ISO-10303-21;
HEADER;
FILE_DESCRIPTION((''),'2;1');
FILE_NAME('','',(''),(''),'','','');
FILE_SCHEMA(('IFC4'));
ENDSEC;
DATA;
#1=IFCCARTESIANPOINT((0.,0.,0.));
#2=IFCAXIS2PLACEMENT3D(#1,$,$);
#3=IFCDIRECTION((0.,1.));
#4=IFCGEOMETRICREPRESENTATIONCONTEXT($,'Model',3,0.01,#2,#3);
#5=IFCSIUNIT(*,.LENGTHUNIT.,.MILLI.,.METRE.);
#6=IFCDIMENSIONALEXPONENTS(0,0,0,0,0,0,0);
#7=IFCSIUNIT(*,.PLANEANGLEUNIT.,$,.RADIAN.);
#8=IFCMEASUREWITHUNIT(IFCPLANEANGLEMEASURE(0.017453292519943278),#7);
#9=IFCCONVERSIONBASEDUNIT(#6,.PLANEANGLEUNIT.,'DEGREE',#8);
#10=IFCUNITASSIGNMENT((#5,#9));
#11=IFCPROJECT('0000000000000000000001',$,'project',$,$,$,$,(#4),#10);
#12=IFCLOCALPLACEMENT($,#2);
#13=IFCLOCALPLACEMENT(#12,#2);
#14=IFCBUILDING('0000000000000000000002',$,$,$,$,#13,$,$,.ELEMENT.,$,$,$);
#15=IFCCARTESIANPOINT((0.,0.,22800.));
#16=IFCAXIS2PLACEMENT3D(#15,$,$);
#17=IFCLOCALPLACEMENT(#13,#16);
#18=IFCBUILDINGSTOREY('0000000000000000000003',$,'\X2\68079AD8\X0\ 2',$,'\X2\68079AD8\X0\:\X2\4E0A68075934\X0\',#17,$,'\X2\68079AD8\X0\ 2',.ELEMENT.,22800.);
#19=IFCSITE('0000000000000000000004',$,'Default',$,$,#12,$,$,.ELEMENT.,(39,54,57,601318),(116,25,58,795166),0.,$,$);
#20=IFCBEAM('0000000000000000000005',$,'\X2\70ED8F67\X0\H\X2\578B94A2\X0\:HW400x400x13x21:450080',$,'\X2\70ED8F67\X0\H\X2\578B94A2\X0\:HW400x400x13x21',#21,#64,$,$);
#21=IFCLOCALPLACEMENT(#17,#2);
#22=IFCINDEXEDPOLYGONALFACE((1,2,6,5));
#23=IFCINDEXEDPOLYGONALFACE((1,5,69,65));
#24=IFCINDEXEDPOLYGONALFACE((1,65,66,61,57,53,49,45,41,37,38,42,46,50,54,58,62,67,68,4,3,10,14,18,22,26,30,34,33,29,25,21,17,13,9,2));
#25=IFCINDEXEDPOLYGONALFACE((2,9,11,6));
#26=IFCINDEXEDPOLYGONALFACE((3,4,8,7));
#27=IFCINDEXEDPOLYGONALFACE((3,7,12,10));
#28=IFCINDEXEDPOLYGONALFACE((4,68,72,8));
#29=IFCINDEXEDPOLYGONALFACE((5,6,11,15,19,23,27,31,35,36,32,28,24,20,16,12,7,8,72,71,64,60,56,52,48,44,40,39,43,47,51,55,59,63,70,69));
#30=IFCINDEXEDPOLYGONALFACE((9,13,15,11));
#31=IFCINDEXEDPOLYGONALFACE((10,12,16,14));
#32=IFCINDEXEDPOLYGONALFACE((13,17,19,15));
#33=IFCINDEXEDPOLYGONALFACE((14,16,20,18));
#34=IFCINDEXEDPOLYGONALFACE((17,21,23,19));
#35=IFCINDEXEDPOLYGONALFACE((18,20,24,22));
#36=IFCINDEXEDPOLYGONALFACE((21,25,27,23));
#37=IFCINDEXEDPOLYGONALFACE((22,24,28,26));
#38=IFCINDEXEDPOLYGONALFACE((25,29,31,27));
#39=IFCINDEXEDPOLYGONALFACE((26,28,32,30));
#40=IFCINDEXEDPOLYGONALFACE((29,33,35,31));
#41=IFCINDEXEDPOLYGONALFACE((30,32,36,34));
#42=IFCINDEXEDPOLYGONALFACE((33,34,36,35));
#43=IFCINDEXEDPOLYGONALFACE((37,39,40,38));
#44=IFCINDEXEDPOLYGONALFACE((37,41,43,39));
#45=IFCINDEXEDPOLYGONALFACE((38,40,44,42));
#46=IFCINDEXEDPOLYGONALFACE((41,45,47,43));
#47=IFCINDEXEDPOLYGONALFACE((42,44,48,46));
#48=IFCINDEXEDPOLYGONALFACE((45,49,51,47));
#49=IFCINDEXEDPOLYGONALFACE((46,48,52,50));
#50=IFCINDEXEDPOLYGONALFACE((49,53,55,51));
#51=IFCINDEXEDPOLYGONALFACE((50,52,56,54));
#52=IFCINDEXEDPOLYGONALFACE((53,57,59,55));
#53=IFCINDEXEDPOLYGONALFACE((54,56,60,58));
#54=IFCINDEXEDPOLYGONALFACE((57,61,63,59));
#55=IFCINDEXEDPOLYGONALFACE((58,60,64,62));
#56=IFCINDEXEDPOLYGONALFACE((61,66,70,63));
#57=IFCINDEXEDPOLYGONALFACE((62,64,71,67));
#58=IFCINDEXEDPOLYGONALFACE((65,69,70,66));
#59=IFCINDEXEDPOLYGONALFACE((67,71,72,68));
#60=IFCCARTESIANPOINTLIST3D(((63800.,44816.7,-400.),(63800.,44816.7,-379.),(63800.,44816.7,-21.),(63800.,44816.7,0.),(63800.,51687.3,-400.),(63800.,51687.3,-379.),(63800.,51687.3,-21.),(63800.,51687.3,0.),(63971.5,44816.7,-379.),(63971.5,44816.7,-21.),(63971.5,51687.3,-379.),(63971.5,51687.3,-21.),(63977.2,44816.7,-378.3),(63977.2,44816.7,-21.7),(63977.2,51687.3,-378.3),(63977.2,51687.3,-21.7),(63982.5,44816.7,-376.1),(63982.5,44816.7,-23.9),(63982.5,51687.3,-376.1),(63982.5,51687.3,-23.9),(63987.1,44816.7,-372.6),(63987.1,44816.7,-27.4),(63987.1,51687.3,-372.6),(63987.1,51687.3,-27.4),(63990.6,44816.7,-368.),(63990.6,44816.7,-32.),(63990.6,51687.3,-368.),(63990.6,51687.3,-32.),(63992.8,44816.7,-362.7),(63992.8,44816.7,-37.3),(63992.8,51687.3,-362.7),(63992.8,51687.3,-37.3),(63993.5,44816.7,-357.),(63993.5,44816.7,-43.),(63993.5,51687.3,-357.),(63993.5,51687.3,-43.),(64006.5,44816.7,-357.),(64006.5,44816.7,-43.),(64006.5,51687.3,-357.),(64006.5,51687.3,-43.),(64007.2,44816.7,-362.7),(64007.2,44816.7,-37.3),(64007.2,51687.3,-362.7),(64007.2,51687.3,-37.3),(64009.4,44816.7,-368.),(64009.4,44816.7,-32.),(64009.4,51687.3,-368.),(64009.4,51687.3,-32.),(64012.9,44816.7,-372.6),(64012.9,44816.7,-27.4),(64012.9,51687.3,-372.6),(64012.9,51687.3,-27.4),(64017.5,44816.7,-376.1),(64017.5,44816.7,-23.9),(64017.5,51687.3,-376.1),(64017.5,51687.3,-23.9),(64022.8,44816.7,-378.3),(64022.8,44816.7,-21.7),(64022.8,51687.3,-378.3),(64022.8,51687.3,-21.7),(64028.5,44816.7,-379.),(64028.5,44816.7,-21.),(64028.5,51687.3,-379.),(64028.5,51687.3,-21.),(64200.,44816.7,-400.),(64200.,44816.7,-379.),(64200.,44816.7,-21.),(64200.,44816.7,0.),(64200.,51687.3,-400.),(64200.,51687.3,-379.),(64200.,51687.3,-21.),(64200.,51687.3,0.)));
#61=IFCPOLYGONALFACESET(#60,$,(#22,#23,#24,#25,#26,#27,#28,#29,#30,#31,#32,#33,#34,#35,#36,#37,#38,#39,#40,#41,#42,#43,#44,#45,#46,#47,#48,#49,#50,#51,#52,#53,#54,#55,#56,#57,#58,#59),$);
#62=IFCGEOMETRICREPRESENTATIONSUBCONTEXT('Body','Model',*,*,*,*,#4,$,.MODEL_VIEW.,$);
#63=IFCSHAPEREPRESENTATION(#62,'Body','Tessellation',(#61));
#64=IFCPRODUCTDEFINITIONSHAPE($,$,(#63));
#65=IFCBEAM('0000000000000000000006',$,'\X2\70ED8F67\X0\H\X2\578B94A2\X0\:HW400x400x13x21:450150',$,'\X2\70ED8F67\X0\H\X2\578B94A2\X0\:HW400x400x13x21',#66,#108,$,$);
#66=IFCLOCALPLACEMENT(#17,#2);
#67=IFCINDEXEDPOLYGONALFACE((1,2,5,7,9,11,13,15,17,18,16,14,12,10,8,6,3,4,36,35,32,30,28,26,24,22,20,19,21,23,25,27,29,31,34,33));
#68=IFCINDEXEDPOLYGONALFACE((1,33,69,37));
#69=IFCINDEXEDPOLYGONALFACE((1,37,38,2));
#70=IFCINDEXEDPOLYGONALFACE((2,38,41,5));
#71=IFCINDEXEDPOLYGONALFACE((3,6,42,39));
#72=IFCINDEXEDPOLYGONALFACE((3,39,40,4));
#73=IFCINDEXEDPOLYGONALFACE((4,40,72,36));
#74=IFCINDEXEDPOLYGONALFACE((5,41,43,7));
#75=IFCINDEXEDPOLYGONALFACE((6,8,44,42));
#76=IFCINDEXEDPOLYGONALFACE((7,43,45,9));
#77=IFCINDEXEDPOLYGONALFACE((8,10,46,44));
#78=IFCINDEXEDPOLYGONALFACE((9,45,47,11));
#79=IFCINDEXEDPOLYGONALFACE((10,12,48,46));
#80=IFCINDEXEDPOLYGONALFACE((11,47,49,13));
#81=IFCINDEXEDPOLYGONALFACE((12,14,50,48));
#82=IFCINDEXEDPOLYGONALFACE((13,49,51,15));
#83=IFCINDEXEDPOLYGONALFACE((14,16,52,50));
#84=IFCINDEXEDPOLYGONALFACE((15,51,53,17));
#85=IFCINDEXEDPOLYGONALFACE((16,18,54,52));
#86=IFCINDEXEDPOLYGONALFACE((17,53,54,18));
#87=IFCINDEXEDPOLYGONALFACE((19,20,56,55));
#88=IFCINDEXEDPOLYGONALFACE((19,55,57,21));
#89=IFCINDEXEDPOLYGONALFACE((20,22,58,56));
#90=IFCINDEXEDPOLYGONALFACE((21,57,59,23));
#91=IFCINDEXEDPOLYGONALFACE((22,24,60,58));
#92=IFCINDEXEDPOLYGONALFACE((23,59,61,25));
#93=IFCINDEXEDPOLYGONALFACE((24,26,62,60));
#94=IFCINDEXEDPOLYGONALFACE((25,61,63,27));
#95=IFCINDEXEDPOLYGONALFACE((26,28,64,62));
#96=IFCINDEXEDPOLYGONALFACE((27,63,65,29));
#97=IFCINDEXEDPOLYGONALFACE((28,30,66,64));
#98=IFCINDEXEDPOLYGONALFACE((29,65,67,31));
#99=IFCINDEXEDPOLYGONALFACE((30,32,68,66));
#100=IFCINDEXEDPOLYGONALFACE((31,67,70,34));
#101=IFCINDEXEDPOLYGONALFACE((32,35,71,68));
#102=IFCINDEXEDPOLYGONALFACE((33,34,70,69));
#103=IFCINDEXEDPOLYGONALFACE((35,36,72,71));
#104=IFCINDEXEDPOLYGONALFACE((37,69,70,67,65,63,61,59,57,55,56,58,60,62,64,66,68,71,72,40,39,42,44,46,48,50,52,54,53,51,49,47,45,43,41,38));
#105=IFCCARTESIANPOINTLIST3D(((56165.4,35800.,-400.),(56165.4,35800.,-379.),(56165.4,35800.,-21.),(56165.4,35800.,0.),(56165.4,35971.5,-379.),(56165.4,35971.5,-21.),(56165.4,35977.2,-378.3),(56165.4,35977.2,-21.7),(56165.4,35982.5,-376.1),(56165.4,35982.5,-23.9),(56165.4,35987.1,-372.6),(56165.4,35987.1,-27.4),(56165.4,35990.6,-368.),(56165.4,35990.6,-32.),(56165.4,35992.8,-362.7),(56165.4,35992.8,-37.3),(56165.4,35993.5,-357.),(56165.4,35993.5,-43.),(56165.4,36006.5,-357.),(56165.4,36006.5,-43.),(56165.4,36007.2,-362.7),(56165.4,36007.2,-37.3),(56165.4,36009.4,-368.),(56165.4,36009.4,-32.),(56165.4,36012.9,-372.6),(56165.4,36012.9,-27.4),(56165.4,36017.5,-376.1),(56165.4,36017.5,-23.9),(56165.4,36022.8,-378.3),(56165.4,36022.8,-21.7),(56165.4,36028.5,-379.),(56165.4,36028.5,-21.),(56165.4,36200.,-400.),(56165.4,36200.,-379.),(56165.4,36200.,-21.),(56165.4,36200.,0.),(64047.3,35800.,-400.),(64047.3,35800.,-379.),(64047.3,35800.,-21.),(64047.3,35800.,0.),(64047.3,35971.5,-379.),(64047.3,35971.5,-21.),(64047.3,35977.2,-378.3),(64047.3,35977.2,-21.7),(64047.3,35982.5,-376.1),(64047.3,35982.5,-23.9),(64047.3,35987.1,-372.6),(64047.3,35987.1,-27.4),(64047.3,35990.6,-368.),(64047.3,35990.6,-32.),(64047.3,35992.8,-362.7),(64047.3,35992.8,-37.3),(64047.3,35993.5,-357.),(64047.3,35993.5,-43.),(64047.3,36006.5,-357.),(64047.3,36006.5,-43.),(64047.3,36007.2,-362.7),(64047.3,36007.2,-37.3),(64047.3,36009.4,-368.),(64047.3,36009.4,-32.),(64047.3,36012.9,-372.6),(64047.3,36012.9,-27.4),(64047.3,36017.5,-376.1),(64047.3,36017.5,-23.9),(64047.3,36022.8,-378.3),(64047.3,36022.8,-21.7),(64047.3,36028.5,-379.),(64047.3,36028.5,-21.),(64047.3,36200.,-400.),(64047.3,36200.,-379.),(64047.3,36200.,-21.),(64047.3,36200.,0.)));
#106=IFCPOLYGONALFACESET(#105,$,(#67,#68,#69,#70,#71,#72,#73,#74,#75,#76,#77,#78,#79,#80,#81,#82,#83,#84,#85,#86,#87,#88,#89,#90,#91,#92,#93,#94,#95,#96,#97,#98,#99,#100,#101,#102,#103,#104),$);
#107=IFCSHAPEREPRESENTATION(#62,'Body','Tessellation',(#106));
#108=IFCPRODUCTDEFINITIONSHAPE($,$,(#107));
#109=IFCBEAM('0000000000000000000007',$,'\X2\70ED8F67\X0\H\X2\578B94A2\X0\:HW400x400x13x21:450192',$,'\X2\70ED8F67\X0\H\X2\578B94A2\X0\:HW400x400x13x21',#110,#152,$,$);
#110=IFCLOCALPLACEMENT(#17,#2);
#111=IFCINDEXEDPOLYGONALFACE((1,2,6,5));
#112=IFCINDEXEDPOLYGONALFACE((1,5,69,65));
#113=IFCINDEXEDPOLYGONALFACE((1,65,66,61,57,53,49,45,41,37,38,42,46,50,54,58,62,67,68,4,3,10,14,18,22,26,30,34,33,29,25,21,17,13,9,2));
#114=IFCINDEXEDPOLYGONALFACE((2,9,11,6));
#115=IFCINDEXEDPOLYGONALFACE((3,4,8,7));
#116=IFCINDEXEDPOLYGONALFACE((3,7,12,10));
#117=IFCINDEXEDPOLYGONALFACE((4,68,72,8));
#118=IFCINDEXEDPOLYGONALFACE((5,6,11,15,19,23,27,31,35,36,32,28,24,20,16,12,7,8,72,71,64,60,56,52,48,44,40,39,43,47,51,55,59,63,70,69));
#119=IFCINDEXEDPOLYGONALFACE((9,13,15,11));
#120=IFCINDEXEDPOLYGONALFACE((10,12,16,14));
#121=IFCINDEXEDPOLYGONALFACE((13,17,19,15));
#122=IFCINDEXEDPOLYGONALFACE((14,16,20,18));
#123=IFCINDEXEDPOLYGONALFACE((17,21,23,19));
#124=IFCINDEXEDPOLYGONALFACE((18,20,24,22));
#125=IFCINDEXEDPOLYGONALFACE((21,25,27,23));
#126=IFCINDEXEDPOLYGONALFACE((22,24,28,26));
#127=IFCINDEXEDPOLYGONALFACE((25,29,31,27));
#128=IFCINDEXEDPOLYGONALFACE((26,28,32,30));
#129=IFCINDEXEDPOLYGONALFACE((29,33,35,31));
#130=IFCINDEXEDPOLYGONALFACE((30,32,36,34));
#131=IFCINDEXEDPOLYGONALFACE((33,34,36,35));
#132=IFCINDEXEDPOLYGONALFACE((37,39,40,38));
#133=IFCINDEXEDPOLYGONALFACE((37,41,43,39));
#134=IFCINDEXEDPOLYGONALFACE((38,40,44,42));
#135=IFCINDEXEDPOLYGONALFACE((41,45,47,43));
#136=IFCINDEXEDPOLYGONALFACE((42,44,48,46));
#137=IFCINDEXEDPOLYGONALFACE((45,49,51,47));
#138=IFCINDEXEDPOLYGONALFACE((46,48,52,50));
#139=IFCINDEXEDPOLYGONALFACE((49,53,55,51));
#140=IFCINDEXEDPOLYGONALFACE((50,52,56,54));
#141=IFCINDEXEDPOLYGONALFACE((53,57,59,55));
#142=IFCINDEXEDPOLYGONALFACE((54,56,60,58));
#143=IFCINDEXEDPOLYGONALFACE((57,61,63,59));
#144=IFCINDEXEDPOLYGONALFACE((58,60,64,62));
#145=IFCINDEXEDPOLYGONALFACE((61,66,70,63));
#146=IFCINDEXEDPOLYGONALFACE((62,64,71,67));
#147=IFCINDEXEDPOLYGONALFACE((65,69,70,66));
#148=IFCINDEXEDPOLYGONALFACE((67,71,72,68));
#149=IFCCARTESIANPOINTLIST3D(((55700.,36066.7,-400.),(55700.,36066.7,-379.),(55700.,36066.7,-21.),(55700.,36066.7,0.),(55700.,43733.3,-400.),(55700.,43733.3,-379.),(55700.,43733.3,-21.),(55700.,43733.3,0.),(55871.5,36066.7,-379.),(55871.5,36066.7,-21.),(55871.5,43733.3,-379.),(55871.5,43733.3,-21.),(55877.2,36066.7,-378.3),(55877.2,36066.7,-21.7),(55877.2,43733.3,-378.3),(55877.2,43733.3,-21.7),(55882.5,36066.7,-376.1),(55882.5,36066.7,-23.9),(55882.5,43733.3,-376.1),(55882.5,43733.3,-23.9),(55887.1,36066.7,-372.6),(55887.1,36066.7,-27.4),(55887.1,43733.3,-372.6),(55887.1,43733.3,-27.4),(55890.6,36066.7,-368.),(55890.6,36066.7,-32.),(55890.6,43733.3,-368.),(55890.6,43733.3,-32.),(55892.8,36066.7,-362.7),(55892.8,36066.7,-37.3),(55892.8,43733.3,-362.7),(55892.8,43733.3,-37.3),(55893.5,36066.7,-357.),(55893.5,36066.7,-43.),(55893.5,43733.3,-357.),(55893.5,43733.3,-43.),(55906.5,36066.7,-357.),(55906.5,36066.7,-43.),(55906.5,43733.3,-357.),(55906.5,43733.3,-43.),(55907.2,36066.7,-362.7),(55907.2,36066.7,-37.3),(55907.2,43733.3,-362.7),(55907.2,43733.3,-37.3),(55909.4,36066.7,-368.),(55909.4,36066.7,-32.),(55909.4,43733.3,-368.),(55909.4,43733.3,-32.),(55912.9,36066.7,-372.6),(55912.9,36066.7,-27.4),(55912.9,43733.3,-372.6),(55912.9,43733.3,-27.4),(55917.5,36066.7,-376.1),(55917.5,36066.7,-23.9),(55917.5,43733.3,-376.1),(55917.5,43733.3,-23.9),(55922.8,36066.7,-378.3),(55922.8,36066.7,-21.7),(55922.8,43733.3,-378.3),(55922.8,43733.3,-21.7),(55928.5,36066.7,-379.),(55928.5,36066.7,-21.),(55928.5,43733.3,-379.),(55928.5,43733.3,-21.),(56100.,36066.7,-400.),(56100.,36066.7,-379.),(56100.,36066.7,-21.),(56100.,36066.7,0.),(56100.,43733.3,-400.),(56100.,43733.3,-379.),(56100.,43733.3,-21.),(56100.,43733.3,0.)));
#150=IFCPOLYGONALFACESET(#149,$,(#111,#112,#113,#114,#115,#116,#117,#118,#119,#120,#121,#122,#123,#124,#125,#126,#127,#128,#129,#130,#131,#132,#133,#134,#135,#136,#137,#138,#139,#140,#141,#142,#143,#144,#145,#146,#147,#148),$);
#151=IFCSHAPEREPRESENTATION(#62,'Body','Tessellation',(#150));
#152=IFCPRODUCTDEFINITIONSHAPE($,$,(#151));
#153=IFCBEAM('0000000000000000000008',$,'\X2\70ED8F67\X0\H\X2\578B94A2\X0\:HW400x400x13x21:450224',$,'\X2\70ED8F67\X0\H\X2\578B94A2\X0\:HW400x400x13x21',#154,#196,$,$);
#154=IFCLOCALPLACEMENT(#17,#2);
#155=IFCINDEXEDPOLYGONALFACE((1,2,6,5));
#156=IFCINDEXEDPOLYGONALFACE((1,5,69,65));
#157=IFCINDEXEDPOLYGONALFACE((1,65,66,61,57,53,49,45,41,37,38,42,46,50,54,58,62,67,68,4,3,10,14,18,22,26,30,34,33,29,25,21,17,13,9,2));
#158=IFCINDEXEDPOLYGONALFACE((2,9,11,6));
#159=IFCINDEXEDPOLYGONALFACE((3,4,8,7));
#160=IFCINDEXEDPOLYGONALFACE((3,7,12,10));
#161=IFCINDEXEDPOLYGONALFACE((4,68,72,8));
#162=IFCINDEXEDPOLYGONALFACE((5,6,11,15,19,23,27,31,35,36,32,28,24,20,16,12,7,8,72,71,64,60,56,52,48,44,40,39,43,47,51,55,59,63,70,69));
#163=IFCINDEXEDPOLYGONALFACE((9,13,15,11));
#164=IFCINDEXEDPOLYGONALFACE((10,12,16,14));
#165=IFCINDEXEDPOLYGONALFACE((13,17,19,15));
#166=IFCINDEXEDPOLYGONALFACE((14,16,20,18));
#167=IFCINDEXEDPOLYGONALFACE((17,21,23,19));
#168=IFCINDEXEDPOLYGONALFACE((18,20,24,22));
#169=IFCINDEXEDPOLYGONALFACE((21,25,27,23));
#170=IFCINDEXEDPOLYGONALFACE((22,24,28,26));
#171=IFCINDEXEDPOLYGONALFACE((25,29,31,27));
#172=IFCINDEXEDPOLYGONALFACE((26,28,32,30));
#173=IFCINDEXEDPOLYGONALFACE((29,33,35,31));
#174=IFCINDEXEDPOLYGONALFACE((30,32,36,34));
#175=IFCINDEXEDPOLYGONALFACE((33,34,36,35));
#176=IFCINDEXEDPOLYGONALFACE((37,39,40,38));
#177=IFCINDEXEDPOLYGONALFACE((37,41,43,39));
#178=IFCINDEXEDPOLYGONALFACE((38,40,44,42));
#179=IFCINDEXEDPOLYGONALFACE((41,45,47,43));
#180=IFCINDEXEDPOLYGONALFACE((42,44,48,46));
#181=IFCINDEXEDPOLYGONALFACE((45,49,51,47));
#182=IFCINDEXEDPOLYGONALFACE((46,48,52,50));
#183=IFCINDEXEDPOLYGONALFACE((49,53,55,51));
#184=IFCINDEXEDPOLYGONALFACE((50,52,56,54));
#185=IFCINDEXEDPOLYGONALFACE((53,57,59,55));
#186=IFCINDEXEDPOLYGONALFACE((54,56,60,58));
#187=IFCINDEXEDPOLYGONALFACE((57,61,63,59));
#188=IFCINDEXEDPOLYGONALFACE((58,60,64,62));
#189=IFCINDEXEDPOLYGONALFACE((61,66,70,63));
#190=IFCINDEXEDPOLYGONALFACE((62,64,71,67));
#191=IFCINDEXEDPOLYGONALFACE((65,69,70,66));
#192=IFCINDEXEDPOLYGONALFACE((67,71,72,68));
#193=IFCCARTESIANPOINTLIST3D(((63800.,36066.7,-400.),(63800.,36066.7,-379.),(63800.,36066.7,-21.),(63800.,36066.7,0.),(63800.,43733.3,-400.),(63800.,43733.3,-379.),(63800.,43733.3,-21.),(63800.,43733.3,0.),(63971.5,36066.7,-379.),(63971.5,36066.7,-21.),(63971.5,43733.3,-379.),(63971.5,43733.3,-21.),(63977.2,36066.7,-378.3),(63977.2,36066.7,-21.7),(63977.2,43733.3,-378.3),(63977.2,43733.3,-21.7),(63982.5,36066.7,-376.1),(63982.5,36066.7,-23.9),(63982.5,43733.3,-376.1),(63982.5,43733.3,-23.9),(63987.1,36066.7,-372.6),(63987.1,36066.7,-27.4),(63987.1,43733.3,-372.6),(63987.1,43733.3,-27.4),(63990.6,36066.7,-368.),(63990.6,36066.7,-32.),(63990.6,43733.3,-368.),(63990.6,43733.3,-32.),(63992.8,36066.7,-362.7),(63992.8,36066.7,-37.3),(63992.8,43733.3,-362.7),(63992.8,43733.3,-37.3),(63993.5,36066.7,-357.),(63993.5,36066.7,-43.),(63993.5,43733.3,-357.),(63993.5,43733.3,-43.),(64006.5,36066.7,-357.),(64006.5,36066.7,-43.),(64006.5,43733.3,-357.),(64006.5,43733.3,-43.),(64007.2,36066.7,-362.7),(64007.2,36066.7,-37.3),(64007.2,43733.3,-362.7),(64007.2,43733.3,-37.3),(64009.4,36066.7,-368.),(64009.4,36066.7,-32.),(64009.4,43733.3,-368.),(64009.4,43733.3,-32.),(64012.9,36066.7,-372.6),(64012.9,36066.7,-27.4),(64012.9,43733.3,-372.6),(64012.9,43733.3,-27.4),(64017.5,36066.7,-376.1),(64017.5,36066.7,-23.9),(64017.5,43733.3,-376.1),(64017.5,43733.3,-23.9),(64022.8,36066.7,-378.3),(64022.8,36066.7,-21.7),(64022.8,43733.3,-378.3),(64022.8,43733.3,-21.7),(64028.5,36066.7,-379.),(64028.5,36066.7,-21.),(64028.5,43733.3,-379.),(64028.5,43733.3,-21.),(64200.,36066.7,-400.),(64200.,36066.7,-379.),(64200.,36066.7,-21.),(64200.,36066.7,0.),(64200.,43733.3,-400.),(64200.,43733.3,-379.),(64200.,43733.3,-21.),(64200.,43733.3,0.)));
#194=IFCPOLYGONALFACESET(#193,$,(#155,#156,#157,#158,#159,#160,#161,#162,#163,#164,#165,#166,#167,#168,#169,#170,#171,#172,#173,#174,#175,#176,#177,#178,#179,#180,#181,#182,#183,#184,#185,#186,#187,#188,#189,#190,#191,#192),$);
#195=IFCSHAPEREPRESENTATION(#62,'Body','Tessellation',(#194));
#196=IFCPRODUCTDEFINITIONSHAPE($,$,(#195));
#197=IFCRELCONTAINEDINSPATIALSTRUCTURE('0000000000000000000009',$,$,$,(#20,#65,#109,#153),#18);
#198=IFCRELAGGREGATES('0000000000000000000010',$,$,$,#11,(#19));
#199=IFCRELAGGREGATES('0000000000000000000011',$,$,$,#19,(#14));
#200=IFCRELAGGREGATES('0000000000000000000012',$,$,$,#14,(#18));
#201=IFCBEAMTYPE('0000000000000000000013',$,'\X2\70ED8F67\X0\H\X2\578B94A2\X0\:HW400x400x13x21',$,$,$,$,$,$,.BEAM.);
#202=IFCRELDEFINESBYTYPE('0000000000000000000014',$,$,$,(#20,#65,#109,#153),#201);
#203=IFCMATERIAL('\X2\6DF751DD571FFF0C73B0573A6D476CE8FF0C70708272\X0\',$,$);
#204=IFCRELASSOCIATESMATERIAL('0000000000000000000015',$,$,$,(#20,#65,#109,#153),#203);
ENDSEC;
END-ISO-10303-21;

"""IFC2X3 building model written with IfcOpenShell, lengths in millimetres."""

from ifc_helpers import new_model, entity, si_unit, converted_unit, direction, frame, frame_2d, origin, place, context, subcontext, project, spatial, i_section, extrude, material, type_object, element, save


model = new_model("IFC2X3")

# Units and contexts
model_context = context("Model", 3, precision=0.01, world=origin(), true_north=direction((0.0, 1.0)))
body_context = subcontext(model_context, "Body", "Model", "MODEL_VIEW")
ifc_project = project(units=[si_unit("LENGTHUNIT", "METRE", prefix="MILLI"), converted_unit("PLANEANGLEUNIT", "DEGREE", entity("IfcPlaneAngleMeasure", 0.017453292519943278), si_unit("PLANEANGLEUNIT", "RADIAN"), dimensions=[0, 0, 0, 0, 0, 0, 0])], contexts=[model_context])

# Site, building, storey
site_placement = place(None, origin())
site = spatial("IfcSite", under=ifc_project, at=site_placement, Name="Default", CompositionType="ELEMENT", RefLatitude=(39, 54, 57, 601318), RefLongitude=(116, 25, 58, 795166), RefElevation=0.0)
building_placement = place(site_placement, origin())
building = spatial("IfcBuilding", under=site, at=building_placement, CompositionType="ELEMENT")
storey_placement = place(building_placement, frame((0.0, 0.0, 22800.0)))
storey = spatial("IfcBuildingStorey", under=building, at=storey_placement, Name="标高 2", ObjectType="标高:上标头", LongName="标高 2", CompositionType="ELEMENT", Elevation=22800.0)

# Beams
ifc_material = material(Name="混凝土，现场浇注，灰色")
beam_type = type_object("IfcBeamType", Name="热轧H型钢:HW400x400x13x21", PredefinedType="BEAM")
beam_1_placement = place(storey_placement, frame((64000.0, 51900.0, 0.0), z_axis=(0.0, 0.0, 1.0), x_axis=(0.0, -1.0, 0.0)))
element("IfcBeam", 1, at=beam_1_placement, inside=storey, type_object=beam_type, material=ifc_material, Name="热轧H型钢:HW400x400x13x21:450080", ObjectType="热轧H型钢:HW400x400x13x21", context=body_context, shape_type="SweptSolid", body=[
    extrude(i_section(OverallWidth=400.0, OverallDepth=400.0, WebThickness=13.0, FlangeThickness=21.0, FilletRadius=22.0, at=frame_2d((0.0, 0.0), x_axis=(0.0, 1.0))), frame((212.7, 0.0, -200.0), z_axis=(1.0, 0.0, 0.0), x_axis=(0.0, 0.0, -1.0)), (0.0, 0.0, 1.0), 6870.6),
])
beam_2_placement = place(storey_placement, frame((55900.0, 36000.0, 0.0)))
element("IfcBeam", 2, at=beam_2_placement, inside=storey, type_object=beam_type, material=ifc_material, Name="热轧H型钢:HW400x400x13x21:450150", ObjectType="热轧H型钢:HW400x400x13x21", context=body_context, shape_type="SweptSolid", body=[
    extrude(i_section(OverallWidth=400.0, OverallDepth=400.0, WebThickness=13.0, FlangeThickness=21.0, FilletRadius=22.0, at=frame_2d((0.0, 0.0), x_axis=(0.0, 1.0))), frame((265.4, 0.0, -200.0), z_axis=(1.0, 0.0, 0.0), x_axis=(0.0, 0.0, -1.0)), (0.0, 0.0, 1.0), 7881.9),
])
beam_3_placement = place(storey_placement, frame((55900.0, 43900.0, 0.0), z_axis=(0.0, 0.0, 1.0), x_axis=(0.0, -1.0, 0.0)))
element("IfcBeam", 3, at=beam_3_placement, inside=storey, type_object=beam_type, material=ifc_material, Name="热轧H型钢:HW400x400x13x21:450192", ObjectType="热轧H型钢:HW400x400x13x21", context=body_context, shape_type="SweptSolid", body=[
    extrude(i_section(OverallWidth=400.0, OverallDepth=400.0, WebThickness=13.0, FlangeThickness=21.0, FilletRadius=22.0, at=frame_2d((0.0, 0.0), x_axis=(0.0, 1.0))), frame((166.7, 0.0, -200.0), z_axis=(1.0, 0.0, 0.0), x_axis=(0.0, 0.0, -1.0)), (0.0, 0.0, 1.0), 7666.6),
])
beam_4_placement = place(storey_placement, frame((64000.0, 43900.0, 0.0), z_axis=(0.0, 0.0, 1.0), x_axis=(0.0, -1.0, 0.0)))
element("IfcBeam", 4, at=beam_4_placement, inside=storey, type_object=beam_type, material=ifc_material, Name="热轧H型钢:HW400x400x13x21:450224", ObjectType="热轧H型钢:HW400x400x13x21", context=body_context, shape_type="SweptSolid", body=[
    extrude(i_section(OverallWidth=400.0, OverallDepth=400.0, WebThickness=13.0, FlangeThickness=21.0, FilletRadius=22.0, at=frame_2d((0.0, 0.0), x_axis=(0.0, 1.0))), frame((166.7, 0.0, -200.0), z_axis=(1.0, 0.0, 0.0), x_axis=(0.0, 0.0, -1.0)), (0.0, 0.0, 1.0), 7666.6),
])

save(model, "model.ifc")
